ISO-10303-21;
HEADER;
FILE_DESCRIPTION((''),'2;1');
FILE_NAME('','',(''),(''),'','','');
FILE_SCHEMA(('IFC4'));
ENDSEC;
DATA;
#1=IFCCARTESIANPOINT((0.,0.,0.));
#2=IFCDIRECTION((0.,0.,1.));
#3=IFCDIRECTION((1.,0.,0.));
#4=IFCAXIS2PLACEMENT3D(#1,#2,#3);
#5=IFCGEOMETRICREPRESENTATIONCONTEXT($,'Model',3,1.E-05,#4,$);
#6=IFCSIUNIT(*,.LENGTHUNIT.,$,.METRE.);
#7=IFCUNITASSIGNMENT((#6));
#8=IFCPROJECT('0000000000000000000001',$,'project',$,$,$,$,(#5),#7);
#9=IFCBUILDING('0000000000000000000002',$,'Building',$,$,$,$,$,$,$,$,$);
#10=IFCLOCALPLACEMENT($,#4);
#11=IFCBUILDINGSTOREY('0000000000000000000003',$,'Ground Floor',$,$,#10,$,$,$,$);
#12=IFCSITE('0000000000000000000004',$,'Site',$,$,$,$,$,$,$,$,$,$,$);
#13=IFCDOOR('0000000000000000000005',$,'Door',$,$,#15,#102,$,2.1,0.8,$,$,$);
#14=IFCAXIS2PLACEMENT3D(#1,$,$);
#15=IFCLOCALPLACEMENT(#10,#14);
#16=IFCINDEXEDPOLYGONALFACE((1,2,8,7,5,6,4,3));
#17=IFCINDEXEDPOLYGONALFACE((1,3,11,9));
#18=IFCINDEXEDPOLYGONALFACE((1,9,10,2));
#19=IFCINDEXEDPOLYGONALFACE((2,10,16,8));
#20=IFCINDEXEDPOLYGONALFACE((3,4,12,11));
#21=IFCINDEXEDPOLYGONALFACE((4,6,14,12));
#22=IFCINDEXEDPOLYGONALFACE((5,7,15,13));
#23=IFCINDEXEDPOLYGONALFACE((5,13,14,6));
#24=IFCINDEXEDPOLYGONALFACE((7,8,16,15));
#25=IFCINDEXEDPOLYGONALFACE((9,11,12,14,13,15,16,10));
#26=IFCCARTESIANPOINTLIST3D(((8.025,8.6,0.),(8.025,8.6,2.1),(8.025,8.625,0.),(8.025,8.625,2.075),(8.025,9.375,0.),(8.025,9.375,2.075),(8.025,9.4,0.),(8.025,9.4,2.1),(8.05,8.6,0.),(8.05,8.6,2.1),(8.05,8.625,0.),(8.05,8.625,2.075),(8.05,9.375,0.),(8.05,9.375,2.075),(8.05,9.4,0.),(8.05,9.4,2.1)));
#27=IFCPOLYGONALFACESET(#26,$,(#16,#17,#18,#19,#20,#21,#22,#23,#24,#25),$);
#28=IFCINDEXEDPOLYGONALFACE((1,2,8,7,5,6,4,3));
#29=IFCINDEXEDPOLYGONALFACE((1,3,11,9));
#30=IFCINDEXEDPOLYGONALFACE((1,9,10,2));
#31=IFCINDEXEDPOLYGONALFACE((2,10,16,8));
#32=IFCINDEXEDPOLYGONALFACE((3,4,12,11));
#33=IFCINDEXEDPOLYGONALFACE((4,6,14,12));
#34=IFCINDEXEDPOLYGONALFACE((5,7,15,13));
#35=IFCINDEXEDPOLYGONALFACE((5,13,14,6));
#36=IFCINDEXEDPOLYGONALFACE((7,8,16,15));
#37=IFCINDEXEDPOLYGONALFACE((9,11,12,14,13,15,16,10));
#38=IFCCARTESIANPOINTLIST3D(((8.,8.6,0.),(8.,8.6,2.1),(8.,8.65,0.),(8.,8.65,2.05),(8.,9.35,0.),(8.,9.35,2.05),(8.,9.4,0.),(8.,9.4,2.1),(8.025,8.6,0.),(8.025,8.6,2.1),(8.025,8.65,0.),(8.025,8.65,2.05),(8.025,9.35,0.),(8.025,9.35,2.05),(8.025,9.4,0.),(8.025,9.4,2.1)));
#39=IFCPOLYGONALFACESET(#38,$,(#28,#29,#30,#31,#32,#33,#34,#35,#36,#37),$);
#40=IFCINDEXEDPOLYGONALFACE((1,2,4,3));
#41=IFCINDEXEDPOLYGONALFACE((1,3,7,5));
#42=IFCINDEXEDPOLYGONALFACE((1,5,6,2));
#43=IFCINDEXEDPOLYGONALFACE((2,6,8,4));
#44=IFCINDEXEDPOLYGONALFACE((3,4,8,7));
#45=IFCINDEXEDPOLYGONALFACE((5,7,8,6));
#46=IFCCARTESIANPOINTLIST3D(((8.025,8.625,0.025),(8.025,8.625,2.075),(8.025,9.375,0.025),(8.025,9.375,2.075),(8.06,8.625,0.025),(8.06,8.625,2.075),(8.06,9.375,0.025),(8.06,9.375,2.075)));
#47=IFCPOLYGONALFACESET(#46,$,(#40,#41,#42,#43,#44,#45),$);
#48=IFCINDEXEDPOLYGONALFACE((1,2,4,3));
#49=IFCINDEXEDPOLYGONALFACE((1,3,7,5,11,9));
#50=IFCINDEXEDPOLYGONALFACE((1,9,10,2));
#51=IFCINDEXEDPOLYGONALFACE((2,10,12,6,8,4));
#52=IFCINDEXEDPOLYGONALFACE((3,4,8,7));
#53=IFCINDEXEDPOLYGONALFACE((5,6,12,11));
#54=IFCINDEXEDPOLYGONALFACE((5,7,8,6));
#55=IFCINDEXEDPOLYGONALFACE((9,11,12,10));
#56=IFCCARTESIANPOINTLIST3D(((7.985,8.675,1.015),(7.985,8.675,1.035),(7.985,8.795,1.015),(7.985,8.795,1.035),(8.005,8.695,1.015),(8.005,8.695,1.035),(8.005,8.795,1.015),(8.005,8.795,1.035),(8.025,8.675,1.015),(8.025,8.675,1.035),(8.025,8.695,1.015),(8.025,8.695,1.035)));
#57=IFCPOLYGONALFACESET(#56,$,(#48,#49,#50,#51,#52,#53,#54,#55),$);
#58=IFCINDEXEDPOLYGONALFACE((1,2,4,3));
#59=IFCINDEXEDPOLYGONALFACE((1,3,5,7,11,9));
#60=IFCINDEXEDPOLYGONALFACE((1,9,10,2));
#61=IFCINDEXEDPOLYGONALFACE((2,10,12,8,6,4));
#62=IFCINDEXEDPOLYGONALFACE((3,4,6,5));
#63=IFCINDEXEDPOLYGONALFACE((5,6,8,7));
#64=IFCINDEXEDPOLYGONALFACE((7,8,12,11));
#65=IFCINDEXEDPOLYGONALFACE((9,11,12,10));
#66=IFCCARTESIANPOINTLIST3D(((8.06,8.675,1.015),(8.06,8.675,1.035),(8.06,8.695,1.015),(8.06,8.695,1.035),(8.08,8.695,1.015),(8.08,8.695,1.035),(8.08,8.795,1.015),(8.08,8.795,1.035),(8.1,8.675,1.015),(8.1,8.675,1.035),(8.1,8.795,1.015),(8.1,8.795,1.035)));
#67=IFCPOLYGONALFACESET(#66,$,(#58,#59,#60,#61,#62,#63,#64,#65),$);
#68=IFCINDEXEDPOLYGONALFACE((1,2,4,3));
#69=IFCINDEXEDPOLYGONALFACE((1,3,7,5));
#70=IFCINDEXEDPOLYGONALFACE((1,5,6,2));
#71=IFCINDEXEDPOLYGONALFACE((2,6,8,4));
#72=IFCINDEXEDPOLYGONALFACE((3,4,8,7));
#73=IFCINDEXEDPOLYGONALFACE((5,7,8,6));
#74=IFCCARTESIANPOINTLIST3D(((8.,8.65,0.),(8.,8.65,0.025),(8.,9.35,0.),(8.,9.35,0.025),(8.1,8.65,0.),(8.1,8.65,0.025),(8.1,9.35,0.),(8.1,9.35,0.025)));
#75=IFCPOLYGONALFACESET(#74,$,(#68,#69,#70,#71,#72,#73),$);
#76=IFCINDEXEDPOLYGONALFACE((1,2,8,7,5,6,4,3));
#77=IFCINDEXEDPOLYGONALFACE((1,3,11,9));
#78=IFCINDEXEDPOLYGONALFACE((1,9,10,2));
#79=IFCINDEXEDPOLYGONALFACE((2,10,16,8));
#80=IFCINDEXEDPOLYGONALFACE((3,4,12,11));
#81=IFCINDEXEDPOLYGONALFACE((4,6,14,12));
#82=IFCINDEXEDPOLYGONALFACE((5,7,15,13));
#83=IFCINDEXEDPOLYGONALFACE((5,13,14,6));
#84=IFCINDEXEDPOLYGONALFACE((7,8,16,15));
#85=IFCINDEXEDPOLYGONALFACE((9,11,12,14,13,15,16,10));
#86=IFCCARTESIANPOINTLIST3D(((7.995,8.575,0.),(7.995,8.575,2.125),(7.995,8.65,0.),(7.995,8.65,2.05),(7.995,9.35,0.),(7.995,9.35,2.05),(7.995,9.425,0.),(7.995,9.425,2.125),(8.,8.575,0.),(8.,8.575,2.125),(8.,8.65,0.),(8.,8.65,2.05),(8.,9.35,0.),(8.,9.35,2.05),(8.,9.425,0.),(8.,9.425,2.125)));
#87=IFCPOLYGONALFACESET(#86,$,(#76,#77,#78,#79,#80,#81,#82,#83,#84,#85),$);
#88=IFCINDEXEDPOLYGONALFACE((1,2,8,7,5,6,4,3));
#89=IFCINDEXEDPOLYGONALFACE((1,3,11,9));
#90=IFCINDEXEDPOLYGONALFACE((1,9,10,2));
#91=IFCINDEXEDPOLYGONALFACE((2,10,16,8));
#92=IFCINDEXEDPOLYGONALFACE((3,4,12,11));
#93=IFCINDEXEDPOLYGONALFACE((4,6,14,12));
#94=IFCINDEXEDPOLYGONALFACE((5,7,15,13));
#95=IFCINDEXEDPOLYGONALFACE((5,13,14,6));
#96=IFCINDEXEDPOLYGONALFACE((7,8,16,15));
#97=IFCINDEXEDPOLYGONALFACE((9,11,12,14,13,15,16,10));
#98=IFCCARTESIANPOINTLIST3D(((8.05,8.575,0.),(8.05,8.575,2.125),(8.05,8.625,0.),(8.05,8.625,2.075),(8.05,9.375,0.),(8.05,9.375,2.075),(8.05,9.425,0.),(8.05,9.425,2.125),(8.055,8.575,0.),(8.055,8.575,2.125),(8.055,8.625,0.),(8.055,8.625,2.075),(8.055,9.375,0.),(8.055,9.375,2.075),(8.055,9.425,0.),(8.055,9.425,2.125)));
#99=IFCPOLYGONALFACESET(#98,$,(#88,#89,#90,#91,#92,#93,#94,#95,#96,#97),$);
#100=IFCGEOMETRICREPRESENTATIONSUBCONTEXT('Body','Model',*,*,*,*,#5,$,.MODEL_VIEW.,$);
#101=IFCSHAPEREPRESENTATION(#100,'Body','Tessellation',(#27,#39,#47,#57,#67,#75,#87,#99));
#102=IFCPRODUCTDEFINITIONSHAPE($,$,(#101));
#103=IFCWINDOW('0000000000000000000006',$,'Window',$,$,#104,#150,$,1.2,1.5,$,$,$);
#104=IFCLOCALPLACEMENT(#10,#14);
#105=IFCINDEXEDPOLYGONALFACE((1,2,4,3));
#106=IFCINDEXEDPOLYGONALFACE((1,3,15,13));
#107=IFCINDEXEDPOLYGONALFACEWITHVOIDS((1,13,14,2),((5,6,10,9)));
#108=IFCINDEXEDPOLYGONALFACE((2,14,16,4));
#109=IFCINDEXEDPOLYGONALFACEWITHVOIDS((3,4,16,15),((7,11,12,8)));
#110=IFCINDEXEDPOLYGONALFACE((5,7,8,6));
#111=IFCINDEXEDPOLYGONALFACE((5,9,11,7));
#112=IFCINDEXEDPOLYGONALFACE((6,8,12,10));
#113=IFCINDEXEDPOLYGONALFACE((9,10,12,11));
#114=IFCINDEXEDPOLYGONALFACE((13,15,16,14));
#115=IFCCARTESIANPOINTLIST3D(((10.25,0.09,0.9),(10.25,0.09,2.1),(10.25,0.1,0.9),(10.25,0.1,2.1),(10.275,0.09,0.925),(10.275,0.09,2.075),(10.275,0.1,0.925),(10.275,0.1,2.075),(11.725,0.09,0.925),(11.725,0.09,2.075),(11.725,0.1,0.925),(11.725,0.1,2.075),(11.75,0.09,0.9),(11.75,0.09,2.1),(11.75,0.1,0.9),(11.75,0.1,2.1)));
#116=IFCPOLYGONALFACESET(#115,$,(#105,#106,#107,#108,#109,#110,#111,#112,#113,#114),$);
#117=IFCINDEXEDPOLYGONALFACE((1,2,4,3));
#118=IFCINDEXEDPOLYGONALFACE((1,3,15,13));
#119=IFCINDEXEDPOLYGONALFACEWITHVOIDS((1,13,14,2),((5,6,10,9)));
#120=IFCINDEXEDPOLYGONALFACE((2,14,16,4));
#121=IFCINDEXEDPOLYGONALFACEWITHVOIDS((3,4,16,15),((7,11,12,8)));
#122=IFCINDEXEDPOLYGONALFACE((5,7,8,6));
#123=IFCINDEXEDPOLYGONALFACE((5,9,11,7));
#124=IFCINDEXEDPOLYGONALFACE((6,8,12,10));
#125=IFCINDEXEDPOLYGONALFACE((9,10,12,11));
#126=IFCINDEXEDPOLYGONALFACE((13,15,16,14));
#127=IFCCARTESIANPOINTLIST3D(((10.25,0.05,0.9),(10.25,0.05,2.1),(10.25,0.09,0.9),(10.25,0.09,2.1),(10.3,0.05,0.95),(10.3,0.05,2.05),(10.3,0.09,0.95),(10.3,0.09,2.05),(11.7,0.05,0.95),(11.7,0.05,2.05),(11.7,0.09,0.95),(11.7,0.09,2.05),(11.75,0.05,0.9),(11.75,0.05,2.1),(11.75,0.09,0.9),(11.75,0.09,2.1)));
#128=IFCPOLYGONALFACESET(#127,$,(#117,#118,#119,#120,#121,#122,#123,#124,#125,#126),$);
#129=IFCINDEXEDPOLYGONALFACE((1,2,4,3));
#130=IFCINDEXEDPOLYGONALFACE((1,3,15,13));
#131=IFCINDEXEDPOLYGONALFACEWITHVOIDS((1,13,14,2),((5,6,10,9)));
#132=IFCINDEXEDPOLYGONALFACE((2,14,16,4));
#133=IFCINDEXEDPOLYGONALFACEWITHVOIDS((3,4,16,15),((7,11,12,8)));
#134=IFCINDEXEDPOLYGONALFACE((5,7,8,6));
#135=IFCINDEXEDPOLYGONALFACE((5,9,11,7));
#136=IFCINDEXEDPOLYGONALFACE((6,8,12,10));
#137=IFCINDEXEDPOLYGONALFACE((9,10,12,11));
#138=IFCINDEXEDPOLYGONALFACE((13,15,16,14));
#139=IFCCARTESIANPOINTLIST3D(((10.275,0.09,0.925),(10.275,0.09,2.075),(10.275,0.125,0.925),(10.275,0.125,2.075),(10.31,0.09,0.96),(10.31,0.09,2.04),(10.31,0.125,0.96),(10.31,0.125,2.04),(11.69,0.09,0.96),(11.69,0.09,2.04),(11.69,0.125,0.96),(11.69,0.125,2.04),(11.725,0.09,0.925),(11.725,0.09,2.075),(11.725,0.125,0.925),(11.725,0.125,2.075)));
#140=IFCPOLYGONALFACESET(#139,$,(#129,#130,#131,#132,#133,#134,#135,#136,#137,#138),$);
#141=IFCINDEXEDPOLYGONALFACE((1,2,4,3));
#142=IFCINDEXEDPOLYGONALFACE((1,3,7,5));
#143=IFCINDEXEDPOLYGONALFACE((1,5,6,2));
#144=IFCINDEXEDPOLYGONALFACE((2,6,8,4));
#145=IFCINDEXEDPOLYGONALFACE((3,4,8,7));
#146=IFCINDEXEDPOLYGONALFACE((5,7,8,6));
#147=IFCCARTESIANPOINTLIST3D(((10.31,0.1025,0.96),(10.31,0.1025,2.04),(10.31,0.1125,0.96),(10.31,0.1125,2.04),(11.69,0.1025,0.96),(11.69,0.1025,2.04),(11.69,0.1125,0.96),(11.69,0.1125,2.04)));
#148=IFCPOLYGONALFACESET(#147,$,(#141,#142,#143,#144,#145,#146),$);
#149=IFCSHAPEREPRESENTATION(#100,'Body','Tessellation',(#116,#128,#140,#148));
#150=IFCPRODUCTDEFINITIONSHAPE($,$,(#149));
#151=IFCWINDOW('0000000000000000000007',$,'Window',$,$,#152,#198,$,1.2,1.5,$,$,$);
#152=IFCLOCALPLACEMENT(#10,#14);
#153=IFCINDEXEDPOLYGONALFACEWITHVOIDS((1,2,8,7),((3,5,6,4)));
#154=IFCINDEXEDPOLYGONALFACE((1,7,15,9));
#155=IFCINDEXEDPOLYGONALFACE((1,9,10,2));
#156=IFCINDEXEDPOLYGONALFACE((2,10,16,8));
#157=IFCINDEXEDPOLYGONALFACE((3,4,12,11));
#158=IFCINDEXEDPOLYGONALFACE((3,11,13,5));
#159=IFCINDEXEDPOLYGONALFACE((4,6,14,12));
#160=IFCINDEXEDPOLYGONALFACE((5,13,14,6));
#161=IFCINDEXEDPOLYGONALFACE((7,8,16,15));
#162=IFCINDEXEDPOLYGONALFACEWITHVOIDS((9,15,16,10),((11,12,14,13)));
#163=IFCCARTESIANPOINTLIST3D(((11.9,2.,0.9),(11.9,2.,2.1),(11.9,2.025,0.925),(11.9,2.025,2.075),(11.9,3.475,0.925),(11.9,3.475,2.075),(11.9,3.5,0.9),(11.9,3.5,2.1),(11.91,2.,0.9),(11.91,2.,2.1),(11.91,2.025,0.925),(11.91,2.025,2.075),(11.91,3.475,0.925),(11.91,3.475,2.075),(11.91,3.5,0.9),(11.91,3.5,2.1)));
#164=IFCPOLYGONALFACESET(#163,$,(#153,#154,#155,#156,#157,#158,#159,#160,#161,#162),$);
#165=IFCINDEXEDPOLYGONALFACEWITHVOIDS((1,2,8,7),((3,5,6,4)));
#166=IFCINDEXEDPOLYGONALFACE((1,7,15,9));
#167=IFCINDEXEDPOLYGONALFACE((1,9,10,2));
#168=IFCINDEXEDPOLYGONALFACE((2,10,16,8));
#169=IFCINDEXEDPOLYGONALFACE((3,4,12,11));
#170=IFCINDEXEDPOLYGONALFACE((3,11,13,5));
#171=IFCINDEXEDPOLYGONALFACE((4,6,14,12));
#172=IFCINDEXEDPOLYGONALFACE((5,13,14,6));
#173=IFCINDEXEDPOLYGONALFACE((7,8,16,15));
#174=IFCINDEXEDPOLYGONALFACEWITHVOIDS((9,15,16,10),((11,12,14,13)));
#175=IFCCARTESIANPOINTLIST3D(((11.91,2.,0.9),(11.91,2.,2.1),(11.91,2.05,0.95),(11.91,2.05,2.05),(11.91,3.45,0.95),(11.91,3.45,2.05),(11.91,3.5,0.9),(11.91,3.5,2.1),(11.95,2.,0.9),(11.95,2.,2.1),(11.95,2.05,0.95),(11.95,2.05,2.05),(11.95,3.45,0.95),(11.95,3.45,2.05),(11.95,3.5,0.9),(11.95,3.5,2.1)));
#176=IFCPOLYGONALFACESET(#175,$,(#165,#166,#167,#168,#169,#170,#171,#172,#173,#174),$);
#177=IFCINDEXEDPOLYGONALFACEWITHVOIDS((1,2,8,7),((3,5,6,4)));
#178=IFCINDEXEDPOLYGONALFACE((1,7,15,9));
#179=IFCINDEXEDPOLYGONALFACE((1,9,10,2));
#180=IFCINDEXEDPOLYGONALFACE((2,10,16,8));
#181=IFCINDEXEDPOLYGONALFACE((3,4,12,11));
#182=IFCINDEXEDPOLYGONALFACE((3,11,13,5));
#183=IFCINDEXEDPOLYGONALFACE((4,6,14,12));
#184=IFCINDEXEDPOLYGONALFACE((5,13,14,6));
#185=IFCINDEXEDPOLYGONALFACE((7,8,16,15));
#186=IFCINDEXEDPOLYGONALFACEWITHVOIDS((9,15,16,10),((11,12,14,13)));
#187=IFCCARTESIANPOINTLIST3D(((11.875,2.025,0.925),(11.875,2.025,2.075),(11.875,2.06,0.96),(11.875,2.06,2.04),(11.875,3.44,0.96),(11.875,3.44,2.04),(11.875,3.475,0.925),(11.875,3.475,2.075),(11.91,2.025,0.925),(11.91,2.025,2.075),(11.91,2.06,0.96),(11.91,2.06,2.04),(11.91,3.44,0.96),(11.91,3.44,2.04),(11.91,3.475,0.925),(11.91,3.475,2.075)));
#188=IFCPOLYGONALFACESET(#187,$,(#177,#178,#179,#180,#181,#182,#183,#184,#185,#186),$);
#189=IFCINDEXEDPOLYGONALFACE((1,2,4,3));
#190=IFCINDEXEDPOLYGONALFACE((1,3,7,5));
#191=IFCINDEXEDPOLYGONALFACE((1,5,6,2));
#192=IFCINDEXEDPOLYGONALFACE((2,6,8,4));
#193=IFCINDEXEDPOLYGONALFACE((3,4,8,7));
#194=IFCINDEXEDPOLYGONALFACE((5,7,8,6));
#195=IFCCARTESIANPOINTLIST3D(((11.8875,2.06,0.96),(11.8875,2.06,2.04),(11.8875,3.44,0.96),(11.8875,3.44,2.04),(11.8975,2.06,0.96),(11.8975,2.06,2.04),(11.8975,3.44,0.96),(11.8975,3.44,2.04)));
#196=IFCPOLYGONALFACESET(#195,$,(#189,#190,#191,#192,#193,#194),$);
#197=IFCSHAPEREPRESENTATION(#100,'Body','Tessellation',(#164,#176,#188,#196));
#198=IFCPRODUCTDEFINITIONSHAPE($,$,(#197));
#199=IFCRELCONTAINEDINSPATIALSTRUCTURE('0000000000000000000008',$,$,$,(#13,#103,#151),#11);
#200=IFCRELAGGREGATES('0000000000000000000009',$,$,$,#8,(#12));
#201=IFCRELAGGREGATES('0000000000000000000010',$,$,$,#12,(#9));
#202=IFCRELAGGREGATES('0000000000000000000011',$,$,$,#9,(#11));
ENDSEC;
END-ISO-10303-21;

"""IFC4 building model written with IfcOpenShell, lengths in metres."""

from ifc_helpers import new_model, si_unit, frame, origin_with_axes, place, context, subcontext, project, spatial, line, indexed_curve, outline, extrude, element, save


model = new_model("IFC4")

# Units and contexts
model_context = context("Model", 3, precision=1e-05, world=origin_with_axes())
body_context = subcontext(model_context, "Body", "Model", "MODEL_VIEW")
ifc_project = project(units=[si_unit("LENGTHUNIT", "METRE")], contexts=[model_context])

# Site, building, storey
site = spatial("IfcSite", under=ifc_project, Name="Site")
building = spatial("IfcBuilding", under=site, Name="Building")
storey_placement = place(None, origin_with_axes())
storey = spatial("IfcBuildingStorey", under=building, at=storey_placement, Name="Ground Floor")

# Door
door_1_placement = place(storey_placement, frame((8.0, 9.4, 0.0), z_axis=(0.0, 0.0, 1.0), x_axis=(0.0, -1.0, 0.0)))
element("IfcDoor", 1, at=door_1_placement, inside=storey, Name="Door", OverallHeight=2.1, OverallWidth=0.8, context=body_context, shape_type="SweptSolid", body=[
    extrude(outline(indexed_curve([(0.0, 0.0), (0.0, 2.1), (0.8, 2.1), (0.8, 0.0), (0.775, 0.0), (0.775, 2.075), (0.025, 2.075), (0.025, 0.0)], segments=[line(1, 2, 3, 4, 5, 6, 7, 8, 1)])), frame((0.0, 0.025, 0.0), z_axis=(0.0, -1.0, 0.0), x_axis=(1.0, 0.0, 0.0)), (0.0, 0.0, -1.0), 0.025),
    extrude(outline(indexed_curve([(0.0, 0.0), (0.0, 2.1), (0.8, 2.1), (0.8, 0.0), (0.75, 0.0), (0.75, 2.05), (0.05, 2.05), (0.05, 0.0)], segments=[line(1, 2, 3, 4, 5, 6, 7, 8, 1)])), frame((0.0, 0.0, 0.0), z_axis=(0.0, -1.0, 0.0), x_axis=(1.0, 0.0, 0.0)), (0.0, 0.0, -1.0), 0.025),
    extrude(outline(indexed_curve([(0.0, 0.0), (0.75, 0.0), (0.75, 0.035), (0.0, 0.035)], segments=[line(1, 2, 3, 4, 1)])), frame((0.025, 0.025, 0.025), z_axis=(0.0, 0.0, 1.0), x_axis=(1.0, 0.0, 0.0)), (0.0, 0.0, 1.0), 2.05),
    extrude(outline(indexed_curve([(0.0, 0.0), (0.0, -0.04), (-0.12, -0.04), (-0.12, -0.02), (-0.02, -0.02), (-0.02, 0.0)], segments=[line(1, 2, 3, 4, 5, 6, 1)])), frame((0.725, 0.025, 1.015), z_axis=(0.0, 0.0, 1.0), x_axis=(1.0, 0.0, 0.0)), (0.0, 0.0, 1.0), 0.02),
    extrude(outline(indexed_curve([(0.0, 0.0), (0.0, 0.04), (-0.12, 0.04), (-0.12, 0.02), (-0.02, 0.02), (-0.02, 0.0)], segments=[line(1, 2, 3, 4, 5, 6, 1)])), frame((0.725, 0.06, 1.015), z_axis=(0.0, 0.0, 1.0), x_axis=(1.0, 0.0, 0.0)), (0.0, 0.0, 1.0), 0.02),
    extrude(outline(indexed_curve([(0.0, 0.0), (0.7, 0.0), (0.7, 0.1), (0.0, 0.1)], segments=[line(1, 2, 3, 4, 1)])), frame((0.05, 0.0, 0.0), z_axis=(0.0, 0.0, 1.0), x_axis=(1.0, 0.0, 0.0)), (0.0, 0.0, 1.0), 0.025),
    extrude(outline(indexed_curve([(0.0, 0.0), (0.0, 2.125), (0.85, 2.125), (0.85, 0.0), (0.775, 0.0), (0.775, 2.05), (0.075, 2.05), (0.075, 0.0)], segments=[line(1, 2, 3, 4, 5, 6, 7, 8, 1)])), frame((-0.025, -0.005, 0.0), z_axis=(0.0, -1.0, 0.0), x_axis=(1.0, 0.0, 0.0)), (0.0, 0.0, -1.0), 0.005),
    extrude(outline(indexed_curve([(0.0, 0.0), (0.0, 2.125), (0.85, 2.125), (0.85, 0.0), (0.8, 0.0), (0.8, 2.075), (0.05, 2.075), (0.05, 0.0)], segments=[line(1, 2, 3, 4, 5, 6, 7, 8, 1)])), frame((-0.025, 0.05, 0.0), z_axis=(0.0, -1.0, 0.0), x_axis=(1.0, 0.0, 0.0)), (0.0, 0.0, -1.0), 0.005),
])

# Windows
for number, where, z_axis, x_axis, name in (
    (2, (10.25, 0.0, 0.9), (0.0, 0.0, 1.0), (1.0, 0.0, 0.0), "Window"),
    (3, (12.0, 2.0, 0.9), (0.0, 0.0, 1.0), (0.0, 1.0, 0.0), "Window"),
):
    element("IfcWindow", number, at=place(storey_placement, frame(where, z_axis=z_axis, x_axis=x_axis)), inside=storey, Name=name, OverallHeight=1.2, OverallWidth=1.5, context=body_context, shape_type="SweptSolid", body=[
        extrude(outline(indexed_curve([(0.0, 0.0), (1.5, 0.0), (1.5, 1.2), (0.0, 1.2)], segments=[line(1, 2, 3, 4, 1)]), holes=[indexed_curve([(0.025, 0.025), (1.475, 0.025), (1.475, 1.175), (0.025, 1.175)], segments=[line(1, 2, 3, 4, 1)])]), frame((0.0, 0.09, 0.0), z_axis=(0.0, -1.0, 0.0), x_axis=(1.0, 0.0, 0.0)), (0.0, 0.0, -1.0), 0.01),
        extrude(outline(indexed_curve([(0.0, 0.0), (1.5, 0.0), (1.5, 1.2), (0.0, 1.2)], segments=[line(1, 2, 3, 4, 1)]), holes=[indexed_curve([(0.05, 0.05), (1.45, 0.05), (1.45, 1.15), (0.05, 1.15)], segments=[line(1, 2, 3, 4, 1)])]), frame((0.0, 0.05, 0.0), z_axis=(0.0, -1.0, 0.0), x_axis=(1.0, 0.0, 0.0)), (0.0, 0.0, -1.0), 0.04),
        extrude(outline(indexed_curve([(0.0, 0.0), (1.45, 0.0), (1.45, 1.15), (0.0, 1.15)], segments=[line(1, 2, 3, 4, 1)]), holes=[indexed_curve([(0.035, 0.035), (1.415, 0.035), (1.415, 1.115), (0.035, 1.115)], segments=[line(1, 2, 3, 4, 1)])]), frame((0.025, 0.09, 0.025), z_axis=(0.0, -1.0, 0.0), x_axis=(1.0, 0.0, 0.0)), (0.0, 0.0, -1.0), 0.035),
        extrude(outline(indexed_curve([(0.035, 0.035), (1.415, 0.035), (1.415, 1.115), (0.035, 1.115)], segments=[line(1, 2, 3, 4, 1)])), frame((0.025, 0.1025, 0.025), z_axis=(0.0, -1.0, 0.0), x_axis=(1.0, 0.0, 0.0)), (0.0, 0.0, -1.0), 0.01),
    ])

save(model, "model.ifc")
